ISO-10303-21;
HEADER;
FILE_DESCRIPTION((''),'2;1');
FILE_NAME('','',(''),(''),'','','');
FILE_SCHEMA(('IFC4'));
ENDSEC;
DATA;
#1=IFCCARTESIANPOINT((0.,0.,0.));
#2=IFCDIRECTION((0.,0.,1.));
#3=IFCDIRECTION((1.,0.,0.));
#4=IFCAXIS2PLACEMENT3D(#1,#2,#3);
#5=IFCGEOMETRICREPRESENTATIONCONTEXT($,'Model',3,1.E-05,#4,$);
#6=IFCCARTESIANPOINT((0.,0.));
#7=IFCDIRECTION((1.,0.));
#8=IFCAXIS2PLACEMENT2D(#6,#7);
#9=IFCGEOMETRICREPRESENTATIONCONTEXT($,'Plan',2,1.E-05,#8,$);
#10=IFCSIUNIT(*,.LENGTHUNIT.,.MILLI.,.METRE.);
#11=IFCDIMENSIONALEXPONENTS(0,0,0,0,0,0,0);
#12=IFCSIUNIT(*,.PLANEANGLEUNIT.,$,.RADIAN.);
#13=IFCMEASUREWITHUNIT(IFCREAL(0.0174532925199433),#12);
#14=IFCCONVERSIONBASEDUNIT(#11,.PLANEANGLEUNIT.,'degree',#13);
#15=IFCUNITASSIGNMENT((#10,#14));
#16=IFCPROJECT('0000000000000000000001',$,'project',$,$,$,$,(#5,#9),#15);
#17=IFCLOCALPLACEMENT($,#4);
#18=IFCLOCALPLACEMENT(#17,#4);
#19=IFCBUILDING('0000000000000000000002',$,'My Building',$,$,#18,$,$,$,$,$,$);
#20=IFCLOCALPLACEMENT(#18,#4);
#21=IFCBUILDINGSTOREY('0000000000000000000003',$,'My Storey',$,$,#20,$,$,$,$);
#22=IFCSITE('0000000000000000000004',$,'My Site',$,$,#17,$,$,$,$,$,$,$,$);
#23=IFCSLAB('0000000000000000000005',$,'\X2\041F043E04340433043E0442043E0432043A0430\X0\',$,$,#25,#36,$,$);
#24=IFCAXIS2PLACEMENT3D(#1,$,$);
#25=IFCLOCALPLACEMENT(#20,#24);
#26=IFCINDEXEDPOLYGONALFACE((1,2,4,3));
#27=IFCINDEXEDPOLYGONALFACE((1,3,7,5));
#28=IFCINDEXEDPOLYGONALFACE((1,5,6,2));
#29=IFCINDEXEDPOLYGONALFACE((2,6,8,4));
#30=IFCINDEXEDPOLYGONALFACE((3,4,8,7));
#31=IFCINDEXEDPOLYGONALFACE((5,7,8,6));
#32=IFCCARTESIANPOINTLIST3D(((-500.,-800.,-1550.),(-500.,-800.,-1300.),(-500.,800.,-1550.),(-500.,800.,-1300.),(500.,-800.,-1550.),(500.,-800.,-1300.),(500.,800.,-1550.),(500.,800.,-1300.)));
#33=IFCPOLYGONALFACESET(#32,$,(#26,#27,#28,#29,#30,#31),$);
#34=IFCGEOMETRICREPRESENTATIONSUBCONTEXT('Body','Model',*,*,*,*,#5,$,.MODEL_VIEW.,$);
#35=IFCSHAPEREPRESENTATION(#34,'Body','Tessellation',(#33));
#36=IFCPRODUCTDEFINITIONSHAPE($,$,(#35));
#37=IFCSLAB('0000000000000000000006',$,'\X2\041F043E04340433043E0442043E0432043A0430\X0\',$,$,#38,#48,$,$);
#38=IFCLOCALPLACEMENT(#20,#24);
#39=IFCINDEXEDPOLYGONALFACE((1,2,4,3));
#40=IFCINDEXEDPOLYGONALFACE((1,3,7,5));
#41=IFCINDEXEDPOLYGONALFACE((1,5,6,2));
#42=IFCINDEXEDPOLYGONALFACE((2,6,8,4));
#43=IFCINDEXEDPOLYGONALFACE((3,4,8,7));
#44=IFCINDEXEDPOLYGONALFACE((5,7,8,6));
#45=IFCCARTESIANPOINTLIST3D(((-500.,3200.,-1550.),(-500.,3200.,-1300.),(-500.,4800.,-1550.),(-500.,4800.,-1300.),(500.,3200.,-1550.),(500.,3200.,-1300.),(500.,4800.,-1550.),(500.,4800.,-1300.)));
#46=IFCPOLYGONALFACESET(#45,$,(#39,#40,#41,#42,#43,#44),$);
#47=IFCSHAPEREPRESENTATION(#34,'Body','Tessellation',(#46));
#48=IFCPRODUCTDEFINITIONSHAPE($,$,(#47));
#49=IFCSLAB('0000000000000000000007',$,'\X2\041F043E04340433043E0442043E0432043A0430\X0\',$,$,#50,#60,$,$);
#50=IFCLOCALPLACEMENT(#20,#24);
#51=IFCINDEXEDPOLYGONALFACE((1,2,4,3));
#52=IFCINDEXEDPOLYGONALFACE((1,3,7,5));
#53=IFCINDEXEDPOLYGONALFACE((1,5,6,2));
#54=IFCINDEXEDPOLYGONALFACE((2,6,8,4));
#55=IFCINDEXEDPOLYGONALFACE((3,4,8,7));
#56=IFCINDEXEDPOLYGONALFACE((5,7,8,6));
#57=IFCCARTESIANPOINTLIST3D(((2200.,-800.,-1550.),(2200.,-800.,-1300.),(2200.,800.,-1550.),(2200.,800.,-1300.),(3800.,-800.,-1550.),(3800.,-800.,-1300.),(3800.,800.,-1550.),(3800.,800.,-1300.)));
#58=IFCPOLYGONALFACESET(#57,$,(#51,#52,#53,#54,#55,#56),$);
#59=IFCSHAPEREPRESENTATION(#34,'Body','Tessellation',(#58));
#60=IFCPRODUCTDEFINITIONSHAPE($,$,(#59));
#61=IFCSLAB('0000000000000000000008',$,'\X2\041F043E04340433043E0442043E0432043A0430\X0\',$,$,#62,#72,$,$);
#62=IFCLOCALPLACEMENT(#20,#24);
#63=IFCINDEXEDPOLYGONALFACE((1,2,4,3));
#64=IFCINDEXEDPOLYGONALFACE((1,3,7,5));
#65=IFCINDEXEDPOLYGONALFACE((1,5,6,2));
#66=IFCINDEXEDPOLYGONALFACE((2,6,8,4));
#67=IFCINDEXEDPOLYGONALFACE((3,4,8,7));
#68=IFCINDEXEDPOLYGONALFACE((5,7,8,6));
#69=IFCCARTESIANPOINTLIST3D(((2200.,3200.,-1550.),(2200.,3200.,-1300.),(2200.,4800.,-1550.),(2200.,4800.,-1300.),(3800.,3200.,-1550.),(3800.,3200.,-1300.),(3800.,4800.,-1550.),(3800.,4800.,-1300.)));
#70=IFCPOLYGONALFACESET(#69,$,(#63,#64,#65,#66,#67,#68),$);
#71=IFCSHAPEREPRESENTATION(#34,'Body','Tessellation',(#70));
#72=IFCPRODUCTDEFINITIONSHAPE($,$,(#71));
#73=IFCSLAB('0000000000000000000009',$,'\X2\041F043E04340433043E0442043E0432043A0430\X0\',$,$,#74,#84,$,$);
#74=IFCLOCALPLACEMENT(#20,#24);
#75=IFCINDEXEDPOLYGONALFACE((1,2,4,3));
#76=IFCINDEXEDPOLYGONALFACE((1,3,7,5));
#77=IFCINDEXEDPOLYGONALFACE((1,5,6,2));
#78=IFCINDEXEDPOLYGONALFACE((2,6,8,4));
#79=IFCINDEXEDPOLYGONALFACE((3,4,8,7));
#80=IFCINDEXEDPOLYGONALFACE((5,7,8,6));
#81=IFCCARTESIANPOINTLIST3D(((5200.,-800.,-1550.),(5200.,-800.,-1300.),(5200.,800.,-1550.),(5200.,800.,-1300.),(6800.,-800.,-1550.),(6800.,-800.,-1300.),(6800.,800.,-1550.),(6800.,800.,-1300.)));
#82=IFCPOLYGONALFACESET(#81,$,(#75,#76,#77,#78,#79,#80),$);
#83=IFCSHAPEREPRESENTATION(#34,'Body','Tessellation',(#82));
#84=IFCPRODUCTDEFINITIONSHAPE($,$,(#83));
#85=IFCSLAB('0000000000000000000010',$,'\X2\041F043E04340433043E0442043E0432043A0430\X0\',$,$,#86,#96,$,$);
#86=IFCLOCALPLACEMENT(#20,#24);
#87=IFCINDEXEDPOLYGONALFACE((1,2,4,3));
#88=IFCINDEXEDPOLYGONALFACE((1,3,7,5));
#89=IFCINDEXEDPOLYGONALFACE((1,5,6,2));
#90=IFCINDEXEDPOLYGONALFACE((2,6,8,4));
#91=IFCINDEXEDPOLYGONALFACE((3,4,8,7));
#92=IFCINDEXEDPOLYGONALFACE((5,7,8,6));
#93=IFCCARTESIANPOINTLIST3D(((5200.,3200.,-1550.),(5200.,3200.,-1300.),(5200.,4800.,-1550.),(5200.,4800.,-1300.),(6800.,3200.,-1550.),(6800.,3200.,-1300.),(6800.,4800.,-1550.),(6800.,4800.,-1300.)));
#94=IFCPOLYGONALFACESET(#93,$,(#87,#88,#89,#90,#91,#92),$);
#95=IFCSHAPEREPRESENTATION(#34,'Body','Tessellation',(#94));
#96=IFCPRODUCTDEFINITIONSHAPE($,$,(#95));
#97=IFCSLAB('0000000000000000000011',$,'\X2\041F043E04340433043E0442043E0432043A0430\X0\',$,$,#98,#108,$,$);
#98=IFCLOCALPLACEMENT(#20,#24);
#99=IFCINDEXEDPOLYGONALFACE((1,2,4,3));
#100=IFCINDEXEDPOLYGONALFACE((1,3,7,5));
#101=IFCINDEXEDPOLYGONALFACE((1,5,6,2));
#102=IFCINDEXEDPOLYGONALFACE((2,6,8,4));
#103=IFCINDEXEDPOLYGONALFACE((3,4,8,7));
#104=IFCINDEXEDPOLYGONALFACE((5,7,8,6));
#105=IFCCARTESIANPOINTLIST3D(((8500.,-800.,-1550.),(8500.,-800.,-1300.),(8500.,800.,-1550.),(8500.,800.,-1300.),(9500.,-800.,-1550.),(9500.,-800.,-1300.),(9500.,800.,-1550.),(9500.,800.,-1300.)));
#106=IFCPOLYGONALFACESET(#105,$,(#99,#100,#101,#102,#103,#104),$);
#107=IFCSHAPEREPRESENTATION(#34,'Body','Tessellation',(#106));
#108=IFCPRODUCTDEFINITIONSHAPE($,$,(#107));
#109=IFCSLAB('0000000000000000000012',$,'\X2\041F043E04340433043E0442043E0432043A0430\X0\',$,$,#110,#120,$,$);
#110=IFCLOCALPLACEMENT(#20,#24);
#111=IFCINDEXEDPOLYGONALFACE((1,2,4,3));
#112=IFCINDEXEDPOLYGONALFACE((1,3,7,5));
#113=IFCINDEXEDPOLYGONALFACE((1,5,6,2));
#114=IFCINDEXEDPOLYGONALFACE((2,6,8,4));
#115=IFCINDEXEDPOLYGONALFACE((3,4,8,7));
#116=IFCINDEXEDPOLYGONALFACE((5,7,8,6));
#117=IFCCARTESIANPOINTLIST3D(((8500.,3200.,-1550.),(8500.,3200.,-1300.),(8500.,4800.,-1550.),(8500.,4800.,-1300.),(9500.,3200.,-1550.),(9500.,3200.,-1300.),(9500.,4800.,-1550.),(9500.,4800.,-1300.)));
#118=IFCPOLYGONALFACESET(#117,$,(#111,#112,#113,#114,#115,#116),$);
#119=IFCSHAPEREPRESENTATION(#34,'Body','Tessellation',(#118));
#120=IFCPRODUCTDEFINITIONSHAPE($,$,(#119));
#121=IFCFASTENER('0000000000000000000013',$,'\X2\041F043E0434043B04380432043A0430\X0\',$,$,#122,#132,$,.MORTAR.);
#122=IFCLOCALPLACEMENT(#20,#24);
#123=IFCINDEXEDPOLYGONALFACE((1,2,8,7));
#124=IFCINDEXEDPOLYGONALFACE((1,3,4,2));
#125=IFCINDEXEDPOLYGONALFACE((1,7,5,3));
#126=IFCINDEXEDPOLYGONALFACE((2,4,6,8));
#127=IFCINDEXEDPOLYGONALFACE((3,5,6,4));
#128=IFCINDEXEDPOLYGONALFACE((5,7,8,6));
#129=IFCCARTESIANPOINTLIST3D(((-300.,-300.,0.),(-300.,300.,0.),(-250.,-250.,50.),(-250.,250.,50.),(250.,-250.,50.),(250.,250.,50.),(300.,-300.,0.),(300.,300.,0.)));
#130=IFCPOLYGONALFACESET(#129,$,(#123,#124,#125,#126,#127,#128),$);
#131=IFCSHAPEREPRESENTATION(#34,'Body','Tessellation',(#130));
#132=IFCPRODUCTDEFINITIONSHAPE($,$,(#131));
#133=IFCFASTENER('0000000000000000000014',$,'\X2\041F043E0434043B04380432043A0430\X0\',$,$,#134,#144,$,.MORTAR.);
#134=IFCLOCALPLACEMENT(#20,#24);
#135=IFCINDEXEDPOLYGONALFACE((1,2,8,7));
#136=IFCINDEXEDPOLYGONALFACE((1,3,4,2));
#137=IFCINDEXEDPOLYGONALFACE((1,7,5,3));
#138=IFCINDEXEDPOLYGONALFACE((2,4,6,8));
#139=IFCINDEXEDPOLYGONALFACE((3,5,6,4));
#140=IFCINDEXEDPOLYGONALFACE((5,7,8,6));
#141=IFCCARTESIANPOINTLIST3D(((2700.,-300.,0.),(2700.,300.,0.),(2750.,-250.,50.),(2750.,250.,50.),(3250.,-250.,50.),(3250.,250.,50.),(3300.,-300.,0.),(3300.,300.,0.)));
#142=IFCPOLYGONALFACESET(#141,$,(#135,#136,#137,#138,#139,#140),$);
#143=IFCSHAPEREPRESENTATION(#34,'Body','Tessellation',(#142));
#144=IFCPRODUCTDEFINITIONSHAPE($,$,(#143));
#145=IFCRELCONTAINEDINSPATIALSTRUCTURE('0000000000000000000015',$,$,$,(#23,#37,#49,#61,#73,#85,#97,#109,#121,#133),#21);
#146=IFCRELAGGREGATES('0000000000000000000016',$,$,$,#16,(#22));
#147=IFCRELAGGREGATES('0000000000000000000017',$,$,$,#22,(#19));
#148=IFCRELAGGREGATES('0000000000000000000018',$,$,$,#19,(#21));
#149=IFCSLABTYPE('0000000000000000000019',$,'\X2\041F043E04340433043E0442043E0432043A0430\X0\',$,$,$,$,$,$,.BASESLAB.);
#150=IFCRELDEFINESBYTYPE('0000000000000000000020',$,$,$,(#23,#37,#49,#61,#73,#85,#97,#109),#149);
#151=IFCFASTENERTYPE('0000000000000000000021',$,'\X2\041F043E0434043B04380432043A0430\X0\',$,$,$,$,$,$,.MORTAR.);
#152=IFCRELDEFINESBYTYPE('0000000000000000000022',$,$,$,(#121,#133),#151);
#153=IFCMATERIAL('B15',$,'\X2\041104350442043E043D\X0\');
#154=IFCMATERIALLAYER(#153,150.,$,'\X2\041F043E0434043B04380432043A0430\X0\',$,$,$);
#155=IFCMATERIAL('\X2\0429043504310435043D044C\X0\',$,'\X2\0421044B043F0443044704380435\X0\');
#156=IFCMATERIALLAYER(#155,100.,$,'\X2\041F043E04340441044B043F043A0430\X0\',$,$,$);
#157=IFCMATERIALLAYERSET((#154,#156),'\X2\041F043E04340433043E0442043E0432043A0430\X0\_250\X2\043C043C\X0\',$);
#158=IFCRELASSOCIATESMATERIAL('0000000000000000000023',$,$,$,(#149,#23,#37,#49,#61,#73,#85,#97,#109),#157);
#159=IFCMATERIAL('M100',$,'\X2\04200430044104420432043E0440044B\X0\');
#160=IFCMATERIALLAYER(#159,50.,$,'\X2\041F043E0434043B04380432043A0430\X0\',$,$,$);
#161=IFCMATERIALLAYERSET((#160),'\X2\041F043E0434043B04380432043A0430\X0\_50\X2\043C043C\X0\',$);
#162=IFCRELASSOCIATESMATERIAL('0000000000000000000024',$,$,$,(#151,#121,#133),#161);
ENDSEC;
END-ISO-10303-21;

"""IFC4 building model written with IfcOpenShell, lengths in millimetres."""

from ifc_helpers import new_model, entity, si_unit, converted_unit, frame, origin_with_axes, origin_2d_with_axis, place, context, subcontext, project, spatial, line, indexed_curve, outline, extrude, boolean, halfspace, material, layer, layer_set, layer_usage, type_object, element, save


model = new_model("IFC4")

# Units and contexts
model_context = context("Model", 3, precision=1e-05, world=origin_with_axes())
plan_context = context("Plan", 2, precision=1e-05, world=origin_2d_with_axis())
body_context = subcontext(model_context, "Body", "Model", "MODEL_VIEW")
ifc_project = project(units=[si_unit("LENGTHUNIT", "METRE", prefix="MILLI"), converted_unit("PLANEANGLEUNIT", "degree", entity("IfcReal", 0.0174532925199433), si_unit("PLANEANGLEUNIT", "RADIAN"), dimensions=[0, 0, 0, 0, 0, 0, 0])], contexts=[model_context, plan_context])

# Site, building, storey
site_placement = place(None, origin_with_axes())
site = spatial("IfcSite", under=ifc_project, at=site_placement, Name="My Site")
building_placement = place(site_placement, origin_with_axes())
building = spatial("IfcBuilding", under=site, at=building_placement, Name="My Building")
storey_placement = place(building_placement, origin_with_axes())
storey = spatial("IfcBuildingStorey", under=building, at=storey_placement, Name="My Storey")

# Slabs
ifc_material_1 = material(Name="B15", Category="Бетон")
ifc_layer_1 = layer(ifc_material_1, 150.0, Name="Подливка")
ifc_material_2 = material(Name="Щебень", Category="Сыпучие")
ifc_layer_2 = layer(ifc_material_2, 100.0, Name="Подсыпка")
ifc_layer_set_1 = layer_set([ifc_layer_1, ifc_layer_2], Name="Подготовка_250мм")
ifc_layer_usage_1 = layer_usage(ifc_layer_set_1, "AXIS3", "NEGATIVE", 0.0)
slab_type = type_object("IfcSlabType", Name="Подготовка", PredefinedType="BASESLAB", material=ifc_layer_set_1)
slab_1_placement = place(storey_placement, frame((0.0, 0.0, -1550.0), z_axis=(0.0, 0.0, 1.0), x_axis=(1.0, 0.0, 0.0)))
element("IfcSlab", 1, at=slab_1_placement, inside=storey, type_object=slab_type, material=ifc_layer_usage_1, Name="Подготовка", context=body_context, shape_type="SweptSolid", body=[
    extrude(outline(indexed_curve([(-500.0, -800.0), (500.0, -800.0), (500.0, 800.0), (-500.0, 800.0)], segments=[line(3, 2), line(2, 1), line(1, 4), line(4, 3)], self_intersect=False)), None, (0.0, 0.0, 1.0), 250.0),
])
ifc_layer_usage_2 = layer_usage(ifc_layer_set_1, "AXIS3", "NEGATIVE", 0.0)
slab_2_placement = place(storey_placement, frame((0.0, 4000.0, -1550.0), z_axis=(0.0, 0.0, 1.0), x_axis=(1.0, 0.0, 0.0)))
element("IfcSlab", 2, at=slab_2_placement, inside=storey, type_object=slab_type, material=ifc_layer_usage_2, Name="Подготовка", context=body_context, shape_type="SweptSolid", body=[
    extrude(outline(indexed_curve([(-500.0, -800.0), (500.0, -800.0), (500.0, 800.0), (-500.0, 800.0)], segments=[line(3, 2), line(2, 1), line(1, 4), line(4, 3)], self_intersect=False)), None, (0.0, 0.0, 1.0), 250.0),
])
ifc_layer_usage_3 = layer_usage(ifc_layer_set_1, "AXIS3", "NEGATIVE", 0.0)
slab_3_placement = place(storey_placement, frame((3000.0, 0.0, -1550.0), z_axis=(0.0, 0.0, 1.0), x_axis=(1.0, 0.0, 0.0)))
element("IfcSlab", 3, at=slab_3_placement, inside=storey, type_object=slab_type, material=ifc_layer_usage_3, Name="Подготовка", context=body_context, shape_type="SweptSolid", body=[
    extrude(outline(indexed_curve([(800.0, 800.0), (800.0, -800.0), (-800.0, -800.0), (-800.0, 800.0)], segments=[line(3, 2), line(2, 1), line(1, 4), line(4, 3)], self_intersect=False)), None, (0.0, 0.0, 1.0), 250.0),
])
ifc_layer_usage_4 = layer_usage(ifc_layer_set_1, "AXIS3", "NEGATIVE", 0.0)
slab_4_placement = place(storey_placement, frame((3000.0, 4000.0, -1550.0), z_axis=(0.0, 0.0, 1.0), x_axis=(1.0, 0.0, 0.0)))
element("IfcSlab", 4, at=slab_4_placement, inside=storey, type_object=slab_type, material=ifc_layer_usage_4, Name="Подготовка", context=body_context, shape_type="SweptSolid", body=[
    extrude(outline(indexed_curve([(-800.0, -800.0), (800.0, -800.0), (800.0, 800.0), (-800.0, 800.0)], segments=[line(3, 2), line(2, 1), line(1, 4), line(4, 3)], self_intersect=False)), None, (0.0, 0.0, 1.0), 250.0),
])
ifc_layer_usage_5 = layer_usage(ifc_layer_set_1, "AXIS3", "NEGATIVE", 0.0)
slab_5_placement = place(storey_placement, frame((6000.0, 0.0, -1550.0), z_axis=(0.0, 0.0, 1.0), x_axis=(1.0, 0.0, 0.0)))
element("IfcSlab", 5, at=slab_5_placement, inside=storey, type_object=slab_type, material=ifc_layer_usage_5, Name="Подготовка", context=body_context, shape_type="SweptSolid", body=[
    extrude(outline(indexed_curve([(800.0, 800.0), (800.0, -800.0), (-800.0, -800.0), (-800.0, 800.0)], segments=[line(3, 2), line(2, 1), line(1, 4), line(4, 3)], self_intersect=False)), None, (0.0, 0.0, 1.0), 250.0),
])
ifc_layer_usage_6 = layer_usage(ifc_layer_set_1, "AXIS3", "NEGATIVE", 0.0)
slab_6_placement = place(storey_placement, frame((6000.0, 4000.0, -1550.0), z_axis=(0.0, 0.0, 1.0), x_axis=(1.0, 0.0, 0.0)))
element("IfcSlab", 6, at=slab_6_placement, inside=storey, type_object=slab_type, material=ifc_layer_usage_6, Name="Подготовка", context=body_context, shape_type="SweptSolid", body=[
    extrude(outline(indexed_curve([(800.0, 800.0), (800.0, -800.0), (-800.0, -800.0), (-800.0, 800.0)], segments=[line(3, 2), line(2, 1), line(1, 4), line(4, 3)], self_intersect=False)), None, (0.0, 0.0, 1.0), 250.0),
])
ifc_layer_usage_7 = layer_usage(ifc_layer_set_1, "AXIS3", "NEGATIVE", 0.0)
slab_7_placement = place(storey_placement, frame((9000.0, 0.0, -1550.0), z_axis=(0.0, 0.0, 1.0), x_axis=(1.0, 0.0, 0.0)))
element("IfcSlab", 7, at=slab_7_placement, inside=storey, type_object=slab_type, material=ifc_layer_usage_7, Name="Подготовка", context=body_context, shape_type="SweptSolid", body=[
    extrude(outline(indexed_curve([(500.0, 800.0), (500.0, -800.0), (-500.0, -800.0), (-500.0, 800.0)], segments=[line(3, 2), line(2, 1), line(1, 4), line(4, 3)], self_intersect=False)), None, (0.0, 0.0, 1.0), 250.0),
])
ifc_layer_usage_8 = layer_usage(ifc_layer_set_1, "AXIS3", "NEGATIVE", 0.0)
slab_8_placement = place(storey_placement, frame((9000.0, 4000.0, -1550.0), z_axis=(0.0, 0.0, 1.0), x_axis=(1.0, 0.0, 0.0)))
element("IfcSlab", 8, at=slab_8_placement, inside=storey, type_object=slab_type, material=ifc_layer_usage_8, Name="Подготовка", context=body_context, shape_type="SweptSolid", body=[
    extrude(outline(indexed_curve([(-500.0, -800.0), (500.0, -800.0), (500.0, 800.0), (-500.0, 800.0)], segments=[line(3, 2), line(2, 1), line(1, 4), line(4, 3)], self_intersect=False)), None, (0.0, 0.0, 1.0), 250.0),
])

# Fasteners
ifc_material_3 = material(Name="M100", Category="Растворы")
ifc_layer_3 = layer(ifc_material_3, 50.0, Name="Подливка")
ifc_layer_set_2 = layer_set([ifc_layer_3], Name="Подливка_50мм")
ifc_layer_usage_9 = layer_usage(ifc_layer_set_2, "AXIS3", "POSITIVE", 0.0)
fastener_type = type_object("IfcFastenerType", Name="Подливка", PredefinedType="MORTAR", material=ifc_layer_set_2)
fastener_1_placement = place(storey_placement, origin_with_axes())
element("IfcFastener", 9, at=fastener_1_placement, inside=storey, type_object=fastener_type, material=ifc_layer_usage_9, Name="Подливка", PredefinedType="MORTAR", context=body_context, shape_type="Clipping", body=[
    boolean("DIFFERENCE", boolean("DIFFERENCE", boolean("DIFFERENCE", boolean("DIFFERENCE", extrude(outline(indexed_curve([(-300.0, -300.0), (300.0, -300.0), (300.0, 300.0), (-300.0, 300.0)], segments=[line(3, 2), line(2, 1), line(1, 4), line(4, 3)], self_intersect=False)), None, (0.0, 0.0, 1.0), 50.0), halfspace(frame((-53.6, 200.0, 353.6), z_axis=(0.707107, 0.0, 0.707107), x_axis=(0.707107, 0.0, -0.707107)), False)), halfspace(frame((-200.0, -53.6, 353.6), z_axis=(0.0, 0.707107, 0.707107), x_axis=(0.0, 0.707107, -0.707107)), False)), halfspace(frame((200.0, 53.6, 353.6), z_axis=(0.0, -0.707107, 0.707107), x_axis=(0.0, -0.707107, -0.707107)), False)), halfspace(frame((53.6, 200.0, 353.6), z_axis=(-0.707107, 0.0, 0.707107), x_axis=(-0.707107, 0.0, -0.707107)), False)),
])
ifc_layer_usage_10 = layer_usage(ifc_layer_set_2, "AXIS3", "POSITIVE", 0.0)
fastener_2_placement = place(storey_placement, frame((3000.0, 0.0, 0.0), z_axis=(0.0, 0.0, 1.0), x_axis=(1.0, 0.0, 0.0)))
element("IfcFastener", 10, at=fastener_2_placement, inside=storey, type_object=fastener_type, material=ifc_layer_usage_10, Name="Подливка", PredefinedType="MORTAR", context=body_context, shape_type="Clipping", body=[
    boolean("DIFFERENCE", boolean("DIFFERENCE", boolean("DIFFERENCE", boolean("DIFFERENCE", extrude(outline(indexed_curve([(-300.0, -300.0), (300.0, -300.0), (300.0, 300.0), (-300.0, 300.0)], segments=[line(3, 2), line(2, 1), line(1, 4), line(4, 3)], self_intersect=False)), None, (0.0, 0.0, 1.0), 50.0), halfspace(frame((-53.6, 200.0, 353.6), z_axis=(0.707107, 0.0, 0.707107), x_axis=(0.707107, 0.0, -0.707107)), False)), halfspace(frame((-200.0, -53.6, 353.6), z_axis=(0.0, 0.707107, 0.707107), x_axis=(0.0, 0.707107, -0.707107)), False)), halfspace(frame((200.0, 53.6, 353.6), z_axis=(0.0, -0.707107, 0.707107), x_axis=(0.0, -0.707107, -0.707107)), False)), halfspace(frame((53.6, 200.0, 353.6), z_axis=(-0.707107, 0.0, 0.707107), x_axis=(-0.707107, 0.0, -0.707107)), False)),
])

save(model, "model.ifc")
